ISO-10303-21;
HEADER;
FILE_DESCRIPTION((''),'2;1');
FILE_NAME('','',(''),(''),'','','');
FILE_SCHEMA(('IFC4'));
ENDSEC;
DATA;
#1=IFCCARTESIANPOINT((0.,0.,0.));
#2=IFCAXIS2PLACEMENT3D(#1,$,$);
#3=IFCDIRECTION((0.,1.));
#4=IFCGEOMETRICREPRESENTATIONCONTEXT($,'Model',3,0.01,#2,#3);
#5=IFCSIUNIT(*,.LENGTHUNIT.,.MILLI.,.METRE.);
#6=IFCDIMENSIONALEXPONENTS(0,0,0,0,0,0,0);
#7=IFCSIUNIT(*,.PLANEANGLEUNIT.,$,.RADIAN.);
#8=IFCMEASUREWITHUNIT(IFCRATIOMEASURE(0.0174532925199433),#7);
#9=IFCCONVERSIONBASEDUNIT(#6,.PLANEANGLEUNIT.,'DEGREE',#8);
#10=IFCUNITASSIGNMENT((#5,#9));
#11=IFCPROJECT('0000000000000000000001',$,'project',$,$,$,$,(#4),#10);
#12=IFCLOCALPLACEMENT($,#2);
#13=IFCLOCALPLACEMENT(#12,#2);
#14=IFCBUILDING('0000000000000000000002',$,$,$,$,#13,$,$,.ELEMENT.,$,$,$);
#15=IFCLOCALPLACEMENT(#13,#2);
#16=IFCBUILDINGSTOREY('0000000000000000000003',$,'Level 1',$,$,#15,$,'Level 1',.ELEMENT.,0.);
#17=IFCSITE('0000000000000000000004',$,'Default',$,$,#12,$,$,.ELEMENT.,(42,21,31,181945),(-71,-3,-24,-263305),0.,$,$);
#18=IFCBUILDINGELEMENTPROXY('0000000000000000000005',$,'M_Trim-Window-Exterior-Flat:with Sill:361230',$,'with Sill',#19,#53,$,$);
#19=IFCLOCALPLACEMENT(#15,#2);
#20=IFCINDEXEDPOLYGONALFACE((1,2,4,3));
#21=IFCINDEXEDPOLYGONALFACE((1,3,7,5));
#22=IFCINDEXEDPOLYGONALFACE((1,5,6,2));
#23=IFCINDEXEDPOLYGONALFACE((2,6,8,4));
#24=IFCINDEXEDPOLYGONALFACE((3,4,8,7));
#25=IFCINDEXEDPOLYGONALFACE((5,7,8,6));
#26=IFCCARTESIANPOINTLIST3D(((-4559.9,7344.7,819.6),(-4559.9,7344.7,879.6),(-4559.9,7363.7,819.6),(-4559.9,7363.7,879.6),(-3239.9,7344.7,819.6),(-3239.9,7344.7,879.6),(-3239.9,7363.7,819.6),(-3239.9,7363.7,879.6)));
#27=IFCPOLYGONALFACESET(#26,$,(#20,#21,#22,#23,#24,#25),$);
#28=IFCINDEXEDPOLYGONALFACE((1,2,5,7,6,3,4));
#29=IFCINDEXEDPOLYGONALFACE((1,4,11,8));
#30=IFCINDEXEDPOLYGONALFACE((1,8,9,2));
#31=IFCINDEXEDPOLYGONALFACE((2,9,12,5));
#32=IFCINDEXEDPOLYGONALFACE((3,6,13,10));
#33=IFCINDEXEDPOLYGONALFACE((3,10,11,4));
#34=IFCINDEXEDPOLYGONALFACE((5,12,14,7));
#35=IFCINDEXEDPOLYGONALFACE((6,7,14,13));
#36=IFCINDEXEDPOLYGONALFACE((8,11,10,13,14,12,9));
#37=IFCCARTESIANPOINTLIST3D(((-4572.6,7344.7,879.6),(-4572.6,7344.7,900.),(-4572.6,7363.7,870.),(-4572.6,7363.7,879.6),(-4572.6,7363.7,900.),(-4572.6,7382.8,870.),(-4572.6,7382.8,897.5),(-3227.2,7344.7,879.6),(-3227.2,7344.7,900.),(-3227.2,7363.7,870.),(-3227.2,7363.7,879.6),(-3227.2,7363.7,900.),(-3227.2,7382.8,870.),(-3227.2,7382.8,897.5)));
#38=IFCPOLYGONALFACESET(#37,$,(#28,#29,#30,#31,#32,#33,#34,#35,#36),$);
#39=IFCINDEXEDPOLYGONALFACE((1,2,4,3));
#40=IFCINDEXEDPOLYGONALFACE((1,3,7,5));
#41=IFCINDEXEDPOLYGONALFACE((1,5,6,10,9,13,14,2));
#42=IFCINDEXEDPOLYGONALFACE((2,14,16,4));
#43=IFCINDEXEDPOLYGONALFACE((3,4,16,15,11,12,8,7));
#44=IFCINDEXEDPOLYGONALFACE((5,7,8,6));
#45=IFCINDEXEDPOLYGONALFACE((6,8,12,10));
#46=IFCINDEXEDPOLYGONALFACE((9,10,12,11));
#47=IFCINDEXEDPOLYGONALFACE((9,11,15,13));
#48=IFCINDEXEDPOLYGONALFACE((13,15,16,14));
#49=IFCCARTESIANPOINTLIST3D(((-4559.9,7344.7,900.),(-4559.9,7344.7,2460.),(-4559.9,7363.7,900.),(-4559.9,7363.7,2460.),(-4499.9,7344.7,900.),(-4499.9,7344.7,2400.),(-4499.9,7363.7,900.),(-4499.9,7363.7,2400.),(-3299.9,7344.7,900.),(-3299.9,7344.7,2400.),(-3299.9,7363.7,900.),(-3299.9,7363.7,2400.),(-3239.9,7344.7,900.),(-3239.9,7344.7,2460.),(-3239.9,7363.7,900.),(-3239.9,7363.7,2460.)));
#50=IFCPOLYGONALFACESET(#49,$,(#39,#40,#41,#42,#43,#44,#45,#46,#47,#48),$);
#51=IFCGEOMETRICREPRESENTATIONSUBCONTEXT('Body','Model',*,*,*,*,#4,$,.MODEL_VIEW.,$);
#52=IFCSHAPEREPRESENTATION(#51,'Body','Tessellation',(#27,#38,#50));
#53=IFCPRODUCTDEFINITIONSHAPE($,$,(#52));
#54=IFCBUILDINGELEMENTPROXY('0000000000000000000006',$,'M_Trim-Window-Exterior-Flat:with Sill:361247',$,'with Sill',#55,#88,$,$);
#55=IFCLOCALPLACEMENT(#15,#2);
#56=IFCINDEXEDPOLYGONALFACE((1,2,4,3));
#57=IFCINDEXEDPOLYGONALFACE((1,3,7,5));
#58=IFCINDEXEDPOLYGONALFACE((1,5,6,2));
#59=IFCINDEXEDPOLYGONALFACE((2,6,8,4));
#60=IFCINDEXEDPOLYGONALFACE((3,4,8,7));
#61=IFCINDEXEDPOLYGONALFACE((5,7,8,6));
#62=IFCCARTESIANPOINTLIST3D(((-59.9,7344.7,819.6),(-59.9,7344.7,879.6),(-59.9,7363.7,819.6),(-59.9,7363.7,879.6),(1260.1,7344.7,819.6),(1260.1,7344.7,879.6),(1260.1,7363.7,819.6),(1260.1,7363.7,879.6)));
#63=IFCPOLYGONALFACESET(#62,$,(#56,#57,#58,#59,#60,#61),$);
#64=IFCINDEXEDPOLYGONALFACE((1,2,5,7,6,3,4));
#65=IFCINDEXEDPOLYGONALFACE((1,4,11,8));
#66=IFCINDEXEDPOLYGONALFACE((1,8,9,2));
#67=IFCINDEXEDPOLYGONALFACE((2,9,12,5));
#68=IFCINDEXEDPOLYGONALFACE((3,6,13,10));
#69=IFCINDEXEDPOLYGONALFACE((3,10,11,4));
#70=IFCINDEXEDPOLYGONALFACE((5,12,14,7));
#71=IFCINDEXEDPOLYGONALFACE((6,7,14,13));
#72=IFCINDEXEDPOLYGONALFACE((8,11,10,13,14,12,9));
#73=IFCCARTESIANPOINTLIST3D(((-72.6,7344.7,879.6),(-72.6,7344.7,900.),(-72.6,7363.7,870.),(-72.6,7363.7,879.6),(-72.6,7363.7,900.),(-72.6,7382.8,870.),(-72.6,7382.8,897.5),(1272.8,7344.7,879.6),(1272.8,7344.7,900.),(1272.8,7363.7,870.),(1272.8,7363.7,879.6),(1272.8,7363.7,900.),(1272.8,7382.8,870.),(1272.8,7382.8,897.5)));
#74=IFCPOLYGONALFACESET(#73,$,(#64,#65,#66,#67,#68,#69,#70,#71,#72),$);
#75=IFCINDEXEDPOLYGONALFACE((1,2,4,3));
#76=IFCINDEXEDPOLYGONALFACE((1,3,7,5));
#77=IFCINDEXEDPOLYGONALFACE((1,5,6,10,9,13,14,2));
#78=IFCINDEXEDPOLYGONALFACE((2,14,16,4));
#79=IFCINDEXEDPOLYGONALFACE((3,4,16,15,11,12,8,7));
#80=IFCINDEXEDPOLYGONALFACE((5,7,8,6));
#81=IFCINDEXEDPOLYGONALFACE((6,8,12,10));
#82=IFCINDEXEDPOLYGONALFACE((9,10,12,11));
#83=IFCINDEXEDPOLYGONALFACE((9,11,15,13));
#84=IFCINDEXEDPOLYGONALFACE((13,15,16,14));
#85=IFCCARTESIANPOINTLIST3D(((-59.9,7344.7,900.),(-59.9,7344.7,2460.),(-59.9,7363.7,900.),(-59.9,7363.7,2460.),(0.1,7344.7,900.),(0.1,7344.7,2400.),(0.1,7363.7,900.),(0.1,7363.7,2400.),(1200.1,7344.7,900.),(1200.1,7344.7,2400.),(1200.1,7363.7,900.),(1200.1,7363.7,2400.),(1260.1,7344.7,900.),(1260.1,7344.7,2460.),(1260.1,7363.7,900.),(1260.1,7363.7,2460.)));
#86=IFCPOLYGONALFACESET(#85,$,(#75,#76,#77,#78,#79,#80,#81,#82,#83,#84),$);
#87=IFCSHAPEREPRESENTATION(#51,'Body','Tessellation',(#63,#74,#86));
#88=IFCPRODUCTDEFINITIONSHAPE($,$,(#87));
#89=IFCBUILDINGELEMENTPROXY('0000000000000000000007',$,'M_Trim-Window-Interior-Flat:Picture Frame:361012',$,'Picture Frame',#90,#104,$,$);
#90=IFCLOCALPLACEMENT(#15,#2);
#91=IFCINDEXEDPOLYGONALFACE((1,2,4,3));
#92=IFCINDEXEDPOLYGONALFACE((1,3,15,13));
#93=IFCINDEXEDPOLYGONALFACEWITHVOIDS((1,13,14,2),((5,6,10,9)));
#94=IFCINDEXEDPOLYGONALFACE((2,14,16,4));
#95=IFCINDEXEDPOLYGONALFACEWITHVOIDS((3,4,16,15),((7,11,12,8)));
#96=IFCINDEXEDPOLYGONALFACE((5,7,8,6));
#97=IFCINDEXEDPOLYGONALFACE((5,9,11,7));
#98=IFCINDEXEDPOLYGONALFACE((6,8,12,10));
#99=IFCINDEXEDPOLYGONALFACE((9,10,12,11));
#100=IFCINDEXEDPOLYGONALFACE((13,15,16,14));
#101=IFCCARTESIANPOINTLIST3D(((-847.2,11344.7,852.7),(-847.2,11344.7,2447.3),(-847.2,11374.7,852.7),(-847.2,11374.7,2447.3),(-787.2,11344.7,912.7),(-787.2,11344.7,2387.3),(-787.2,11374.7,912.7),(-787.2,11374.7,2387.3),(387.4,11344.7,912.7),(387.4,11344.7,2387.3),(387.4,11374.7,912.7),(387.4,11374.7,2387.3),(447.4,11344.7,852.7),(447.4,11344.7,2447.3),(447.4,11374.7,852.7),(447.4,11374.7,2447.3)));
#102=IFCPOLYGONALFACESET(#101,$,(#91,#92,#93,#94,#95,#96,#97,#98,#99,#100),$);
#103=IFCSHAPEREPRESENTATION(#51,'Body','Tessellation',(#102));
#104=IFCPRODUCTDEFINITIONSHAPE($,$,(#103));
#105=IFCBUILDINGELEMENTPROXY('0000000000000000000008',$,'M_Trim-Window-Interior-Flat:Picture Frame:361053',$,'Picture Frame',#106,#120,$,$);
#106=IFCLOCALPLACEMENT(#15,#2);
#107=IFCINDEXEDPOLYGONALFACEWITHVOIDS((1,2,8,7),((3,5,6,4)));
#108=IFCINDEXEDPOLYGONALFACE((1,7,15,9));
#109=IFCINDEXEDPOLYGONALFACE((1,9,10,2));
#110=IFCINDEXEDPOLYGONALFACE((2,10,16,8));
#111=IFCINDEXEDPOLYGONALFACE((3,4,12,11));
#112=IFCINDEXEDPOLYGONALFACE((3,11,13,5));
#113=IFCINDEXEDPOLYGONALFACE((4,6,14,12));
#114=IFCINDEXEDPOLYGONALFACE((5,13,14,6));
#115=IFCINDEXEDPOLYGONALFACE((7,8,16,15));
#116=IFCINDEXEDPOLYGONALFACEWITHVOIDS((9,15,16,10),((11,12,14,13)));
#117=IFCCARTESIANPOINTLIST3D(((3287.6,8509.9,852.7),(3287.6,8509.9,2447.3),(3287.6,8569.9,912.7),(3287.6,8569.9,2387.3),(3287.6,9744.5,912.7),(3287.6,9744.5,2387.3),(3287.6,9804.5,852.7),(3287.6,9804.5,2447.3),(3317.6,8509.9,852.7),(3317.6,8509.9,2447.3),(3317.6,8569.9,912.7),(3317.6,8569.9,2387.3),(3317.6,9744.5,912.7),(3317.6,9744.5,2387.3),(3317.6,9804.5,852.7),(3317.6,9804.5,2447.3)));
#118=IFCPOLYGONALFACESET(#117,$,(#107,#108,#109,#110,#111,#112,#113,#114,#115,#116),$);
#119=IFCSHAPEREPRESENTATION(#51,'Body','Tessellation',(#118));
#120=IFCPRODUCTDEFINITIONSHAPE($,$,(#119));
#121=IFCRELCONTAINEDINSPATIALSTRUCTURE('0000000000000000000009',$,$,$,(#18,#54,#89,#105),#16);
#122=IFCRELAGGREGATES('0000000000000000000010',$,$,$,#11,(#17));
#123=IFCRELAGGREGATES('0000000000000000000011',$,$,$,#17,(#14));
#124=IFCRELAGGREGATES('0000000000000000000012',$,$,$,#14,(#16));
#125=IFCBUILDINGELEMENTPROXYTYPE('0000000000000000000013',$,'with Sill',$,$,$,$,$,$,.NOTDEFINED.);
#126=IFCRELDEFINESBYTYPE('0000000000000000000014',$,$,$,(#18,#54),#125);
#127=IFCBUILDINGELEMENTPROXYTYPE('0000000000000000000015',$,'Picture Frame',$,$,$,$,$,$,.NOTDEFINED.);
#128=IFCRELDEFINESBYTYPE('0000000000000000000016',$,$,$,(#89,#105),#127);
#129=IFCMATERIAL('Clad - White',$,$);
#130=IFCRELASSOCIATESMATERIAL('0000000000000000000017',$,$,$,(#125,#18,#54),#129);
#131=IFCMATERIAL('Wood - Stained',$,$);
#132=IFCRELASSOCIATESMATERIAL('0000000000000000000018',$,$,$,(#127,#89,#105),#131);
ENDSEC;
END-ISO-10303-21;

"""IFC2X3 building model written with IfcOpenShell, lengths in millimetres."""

from ifc_helpers import new_model, entity, si_unit, converted_unit, direction, frame, frame_2d, origin, place, context, subcontext, project, spatial, polyline, rectangle, outline, extrude, source, transform, mapped, material, type_object, type_shapes, element, save


model = new_model("IFC2X3")

# Units and contexts
model_context = context("Model", 3, precision=0.01, world=origin(), true_north=direction((0.0, 1.0)))
body_context = subcontext(model_context, "Body", "Model", "MODEL_VIEW")
ifc_project = project(units=[si_unit("LENGTHUNIT", "METRE", prefix="MILLI"), converted_unit("PLANEANGLEUNIT", "DEGREE", entity("IfcRatioMeasure", 0.0174532925199433), si_unit("PLANEANGLEUNIT", "RADIAN"), dimensions=[0, 0, 0, 0, 0, 0, 0])], contexts=[model_context])

# Site, building, storey
site_placement = place(None, origin())
site = spatial("IfcSite", under=ifc_project, at=site_placement, Name="Default", CompositionType="ELEMENT", RefLatitude=(42, 21, 31, 181945), RefLongitude=(-71, -3, -24, -263305), RefElevation=0.0)
building_placement = place(site_placement, origin())
building = spatial("IfcBuilding", under=site, at=building_placement, CompositionType="ELEMENT")
storey_placement = place(building_placement, origin())
storey = spatial("IfcBuildingStorey", under=building, at=storey_placement, Name="Level 1", LongName="Level 1", CompositionType="ELEMENT", Elevation=0.0)

# Building element proxies
ifc_material_1 = material(Name="Clad - White")
ifc_material_2 = material(Name="Wood - Stained")
building_element_proxy_type_1 = type_object("IfcBuildingElementProxyType", Name="with Sill", PredefinedType="NOTDEFINED", material=ifc_material_1)
shared_shape_1 = source(origin(), body_context, "Body", "SweptSolid", [
    extrude(rectangle(XDim=1320.0, YDim=60.0, at=frame_2d((0.0, 0.0), x_axis=(1.0, 0.0))), frame((0.0, -1550.4, 0.0), z_axis=(0.0, 0.0, 1.0), x_axis=(-1.0, 0.0, 0.0)), (0.0, 0.0, 1.0), 19.1),
    extrude(outline(polyline([(-19.0, -15.2), (0.0, -15.2), (0.0, -5.7), (19.0, -5.7), (19.0, 14.8), (0.0, 14.8), (-19.0, 12.3), (-19.0, -15.2)])), frame((-672.7, -1514.8, 19.0), z_axis=(1.0, 0.0, 0.0), x_axis=(0.0, 0.0, -1.0)), (0.0, 0.0, 1.0), 1345.4),
    extrude(outline(polyline([(-795.0, -660.0), (765.0, -660.0), (765.0, -600.0), (-735.0, -600.0), (-735.0, 600.0), (765.0, 600.0), (765.0, 660.0), (-795.0, 660.0), (-795.0, -660.0)])), frame((0.0, -735.0, 0.0), z_axis=(0.0, 0.0, 1.0), x_axis=(0.0, -1.0, 0.0)), (0.0, 0.0, 1.0), 19.1),
])
type_shapes(building_element_proxy_type_1, [shared_shape_1])
for number, where, z_axis, x_axis, name in (
    (1, (-3899.9, 7344.7, 2400.0), (0.0, 1.0, 0.0), (-1.0, 0.0, 0.0), "M_Trim-Window-Exterior-Flat:with Sill:361230"),
    (2, (600.1, 7344.7, 2400.0), (0.0, 1.0, 0.0), (-1.0, 0.0, 0.0), "M_Trim-Window-Exterior-Flat:with Sill:361247"),
):
    element("IfcBuildingElementProxy", number, at=place(storey_placement, frame(where, z_axis=z_axis, x_axis=x_axis)), inside=storey, type_object=building_element_proxy_type_1, material=ifc_material_1, Name=name, ObjectType="with Sill", context=body_context, shape_type="MappedRepresentation", body=[
        mapped(shared_shape_1, transform((0.0, 0.0, 0.0), scale=1.0)),
    ])
building_element_proxy_type_2 = type_object("IfcBuildingElementProxyType", Name="Picture Frame", PredefinedType="NOTDEFINED", material=ifc_material_2)
shared_shape_2 = source(origin(), body_context, "Body", "SweptSolid", [
    extrude(outline(polyline([(-647.3, -797.3), (647.3, -797.3), (647.3, 797.3), (-647.3, 797.3), (-647.3, -797.3)]), holes=[polyline([(-587.3, -737.3), (-587.3, 737.3), (587.3, 737.3), (587.3, -737.3), (-587.3, -737.3)])]), frame((0.0, -750.0, 0.0), z_axis=(0.0, 0.0, 1.0), x_axis=(-1.0, 0.0, 0.0)), (0.0, 0.0, 1.0), 30.0),
])
type_shapes(building_element_proxy_type_2, [shared_shape_2])
for number, where, z_axis, x_axis, name in (
    (3, (-199.9, 11344.7, 2400.0), (0.0, 1.0, 0.0), (-1.0, 0.0, 0.0), "M_Trim-Window-Interior-Flat:Picture Frame:361012"),
    (4, (3287.6, 9157.2, 2400.0), (1.0, 0.0, 0.0), (0.0, 1.0, 0.0), "M_Trim-Window-Interior-Flat:Picture Frame:361053"),
):
    element("IfcBuildingElementProxy", number, at=place(storey_placement, frame(where, z_axis=z_axis, x_axis=x_axis)), inside=storey, type_object=building_element_proxy_type_2, material=ifc_material_2, Name=name, ObjectType="Picture Frame", context=body_context, shape_type="MappedRepresentation", body=[
        mapped(shared_shape_2, transform((0.0, 0.0, 0.0), scale=1.0)),
    ])

save(model, "model.ifc")
